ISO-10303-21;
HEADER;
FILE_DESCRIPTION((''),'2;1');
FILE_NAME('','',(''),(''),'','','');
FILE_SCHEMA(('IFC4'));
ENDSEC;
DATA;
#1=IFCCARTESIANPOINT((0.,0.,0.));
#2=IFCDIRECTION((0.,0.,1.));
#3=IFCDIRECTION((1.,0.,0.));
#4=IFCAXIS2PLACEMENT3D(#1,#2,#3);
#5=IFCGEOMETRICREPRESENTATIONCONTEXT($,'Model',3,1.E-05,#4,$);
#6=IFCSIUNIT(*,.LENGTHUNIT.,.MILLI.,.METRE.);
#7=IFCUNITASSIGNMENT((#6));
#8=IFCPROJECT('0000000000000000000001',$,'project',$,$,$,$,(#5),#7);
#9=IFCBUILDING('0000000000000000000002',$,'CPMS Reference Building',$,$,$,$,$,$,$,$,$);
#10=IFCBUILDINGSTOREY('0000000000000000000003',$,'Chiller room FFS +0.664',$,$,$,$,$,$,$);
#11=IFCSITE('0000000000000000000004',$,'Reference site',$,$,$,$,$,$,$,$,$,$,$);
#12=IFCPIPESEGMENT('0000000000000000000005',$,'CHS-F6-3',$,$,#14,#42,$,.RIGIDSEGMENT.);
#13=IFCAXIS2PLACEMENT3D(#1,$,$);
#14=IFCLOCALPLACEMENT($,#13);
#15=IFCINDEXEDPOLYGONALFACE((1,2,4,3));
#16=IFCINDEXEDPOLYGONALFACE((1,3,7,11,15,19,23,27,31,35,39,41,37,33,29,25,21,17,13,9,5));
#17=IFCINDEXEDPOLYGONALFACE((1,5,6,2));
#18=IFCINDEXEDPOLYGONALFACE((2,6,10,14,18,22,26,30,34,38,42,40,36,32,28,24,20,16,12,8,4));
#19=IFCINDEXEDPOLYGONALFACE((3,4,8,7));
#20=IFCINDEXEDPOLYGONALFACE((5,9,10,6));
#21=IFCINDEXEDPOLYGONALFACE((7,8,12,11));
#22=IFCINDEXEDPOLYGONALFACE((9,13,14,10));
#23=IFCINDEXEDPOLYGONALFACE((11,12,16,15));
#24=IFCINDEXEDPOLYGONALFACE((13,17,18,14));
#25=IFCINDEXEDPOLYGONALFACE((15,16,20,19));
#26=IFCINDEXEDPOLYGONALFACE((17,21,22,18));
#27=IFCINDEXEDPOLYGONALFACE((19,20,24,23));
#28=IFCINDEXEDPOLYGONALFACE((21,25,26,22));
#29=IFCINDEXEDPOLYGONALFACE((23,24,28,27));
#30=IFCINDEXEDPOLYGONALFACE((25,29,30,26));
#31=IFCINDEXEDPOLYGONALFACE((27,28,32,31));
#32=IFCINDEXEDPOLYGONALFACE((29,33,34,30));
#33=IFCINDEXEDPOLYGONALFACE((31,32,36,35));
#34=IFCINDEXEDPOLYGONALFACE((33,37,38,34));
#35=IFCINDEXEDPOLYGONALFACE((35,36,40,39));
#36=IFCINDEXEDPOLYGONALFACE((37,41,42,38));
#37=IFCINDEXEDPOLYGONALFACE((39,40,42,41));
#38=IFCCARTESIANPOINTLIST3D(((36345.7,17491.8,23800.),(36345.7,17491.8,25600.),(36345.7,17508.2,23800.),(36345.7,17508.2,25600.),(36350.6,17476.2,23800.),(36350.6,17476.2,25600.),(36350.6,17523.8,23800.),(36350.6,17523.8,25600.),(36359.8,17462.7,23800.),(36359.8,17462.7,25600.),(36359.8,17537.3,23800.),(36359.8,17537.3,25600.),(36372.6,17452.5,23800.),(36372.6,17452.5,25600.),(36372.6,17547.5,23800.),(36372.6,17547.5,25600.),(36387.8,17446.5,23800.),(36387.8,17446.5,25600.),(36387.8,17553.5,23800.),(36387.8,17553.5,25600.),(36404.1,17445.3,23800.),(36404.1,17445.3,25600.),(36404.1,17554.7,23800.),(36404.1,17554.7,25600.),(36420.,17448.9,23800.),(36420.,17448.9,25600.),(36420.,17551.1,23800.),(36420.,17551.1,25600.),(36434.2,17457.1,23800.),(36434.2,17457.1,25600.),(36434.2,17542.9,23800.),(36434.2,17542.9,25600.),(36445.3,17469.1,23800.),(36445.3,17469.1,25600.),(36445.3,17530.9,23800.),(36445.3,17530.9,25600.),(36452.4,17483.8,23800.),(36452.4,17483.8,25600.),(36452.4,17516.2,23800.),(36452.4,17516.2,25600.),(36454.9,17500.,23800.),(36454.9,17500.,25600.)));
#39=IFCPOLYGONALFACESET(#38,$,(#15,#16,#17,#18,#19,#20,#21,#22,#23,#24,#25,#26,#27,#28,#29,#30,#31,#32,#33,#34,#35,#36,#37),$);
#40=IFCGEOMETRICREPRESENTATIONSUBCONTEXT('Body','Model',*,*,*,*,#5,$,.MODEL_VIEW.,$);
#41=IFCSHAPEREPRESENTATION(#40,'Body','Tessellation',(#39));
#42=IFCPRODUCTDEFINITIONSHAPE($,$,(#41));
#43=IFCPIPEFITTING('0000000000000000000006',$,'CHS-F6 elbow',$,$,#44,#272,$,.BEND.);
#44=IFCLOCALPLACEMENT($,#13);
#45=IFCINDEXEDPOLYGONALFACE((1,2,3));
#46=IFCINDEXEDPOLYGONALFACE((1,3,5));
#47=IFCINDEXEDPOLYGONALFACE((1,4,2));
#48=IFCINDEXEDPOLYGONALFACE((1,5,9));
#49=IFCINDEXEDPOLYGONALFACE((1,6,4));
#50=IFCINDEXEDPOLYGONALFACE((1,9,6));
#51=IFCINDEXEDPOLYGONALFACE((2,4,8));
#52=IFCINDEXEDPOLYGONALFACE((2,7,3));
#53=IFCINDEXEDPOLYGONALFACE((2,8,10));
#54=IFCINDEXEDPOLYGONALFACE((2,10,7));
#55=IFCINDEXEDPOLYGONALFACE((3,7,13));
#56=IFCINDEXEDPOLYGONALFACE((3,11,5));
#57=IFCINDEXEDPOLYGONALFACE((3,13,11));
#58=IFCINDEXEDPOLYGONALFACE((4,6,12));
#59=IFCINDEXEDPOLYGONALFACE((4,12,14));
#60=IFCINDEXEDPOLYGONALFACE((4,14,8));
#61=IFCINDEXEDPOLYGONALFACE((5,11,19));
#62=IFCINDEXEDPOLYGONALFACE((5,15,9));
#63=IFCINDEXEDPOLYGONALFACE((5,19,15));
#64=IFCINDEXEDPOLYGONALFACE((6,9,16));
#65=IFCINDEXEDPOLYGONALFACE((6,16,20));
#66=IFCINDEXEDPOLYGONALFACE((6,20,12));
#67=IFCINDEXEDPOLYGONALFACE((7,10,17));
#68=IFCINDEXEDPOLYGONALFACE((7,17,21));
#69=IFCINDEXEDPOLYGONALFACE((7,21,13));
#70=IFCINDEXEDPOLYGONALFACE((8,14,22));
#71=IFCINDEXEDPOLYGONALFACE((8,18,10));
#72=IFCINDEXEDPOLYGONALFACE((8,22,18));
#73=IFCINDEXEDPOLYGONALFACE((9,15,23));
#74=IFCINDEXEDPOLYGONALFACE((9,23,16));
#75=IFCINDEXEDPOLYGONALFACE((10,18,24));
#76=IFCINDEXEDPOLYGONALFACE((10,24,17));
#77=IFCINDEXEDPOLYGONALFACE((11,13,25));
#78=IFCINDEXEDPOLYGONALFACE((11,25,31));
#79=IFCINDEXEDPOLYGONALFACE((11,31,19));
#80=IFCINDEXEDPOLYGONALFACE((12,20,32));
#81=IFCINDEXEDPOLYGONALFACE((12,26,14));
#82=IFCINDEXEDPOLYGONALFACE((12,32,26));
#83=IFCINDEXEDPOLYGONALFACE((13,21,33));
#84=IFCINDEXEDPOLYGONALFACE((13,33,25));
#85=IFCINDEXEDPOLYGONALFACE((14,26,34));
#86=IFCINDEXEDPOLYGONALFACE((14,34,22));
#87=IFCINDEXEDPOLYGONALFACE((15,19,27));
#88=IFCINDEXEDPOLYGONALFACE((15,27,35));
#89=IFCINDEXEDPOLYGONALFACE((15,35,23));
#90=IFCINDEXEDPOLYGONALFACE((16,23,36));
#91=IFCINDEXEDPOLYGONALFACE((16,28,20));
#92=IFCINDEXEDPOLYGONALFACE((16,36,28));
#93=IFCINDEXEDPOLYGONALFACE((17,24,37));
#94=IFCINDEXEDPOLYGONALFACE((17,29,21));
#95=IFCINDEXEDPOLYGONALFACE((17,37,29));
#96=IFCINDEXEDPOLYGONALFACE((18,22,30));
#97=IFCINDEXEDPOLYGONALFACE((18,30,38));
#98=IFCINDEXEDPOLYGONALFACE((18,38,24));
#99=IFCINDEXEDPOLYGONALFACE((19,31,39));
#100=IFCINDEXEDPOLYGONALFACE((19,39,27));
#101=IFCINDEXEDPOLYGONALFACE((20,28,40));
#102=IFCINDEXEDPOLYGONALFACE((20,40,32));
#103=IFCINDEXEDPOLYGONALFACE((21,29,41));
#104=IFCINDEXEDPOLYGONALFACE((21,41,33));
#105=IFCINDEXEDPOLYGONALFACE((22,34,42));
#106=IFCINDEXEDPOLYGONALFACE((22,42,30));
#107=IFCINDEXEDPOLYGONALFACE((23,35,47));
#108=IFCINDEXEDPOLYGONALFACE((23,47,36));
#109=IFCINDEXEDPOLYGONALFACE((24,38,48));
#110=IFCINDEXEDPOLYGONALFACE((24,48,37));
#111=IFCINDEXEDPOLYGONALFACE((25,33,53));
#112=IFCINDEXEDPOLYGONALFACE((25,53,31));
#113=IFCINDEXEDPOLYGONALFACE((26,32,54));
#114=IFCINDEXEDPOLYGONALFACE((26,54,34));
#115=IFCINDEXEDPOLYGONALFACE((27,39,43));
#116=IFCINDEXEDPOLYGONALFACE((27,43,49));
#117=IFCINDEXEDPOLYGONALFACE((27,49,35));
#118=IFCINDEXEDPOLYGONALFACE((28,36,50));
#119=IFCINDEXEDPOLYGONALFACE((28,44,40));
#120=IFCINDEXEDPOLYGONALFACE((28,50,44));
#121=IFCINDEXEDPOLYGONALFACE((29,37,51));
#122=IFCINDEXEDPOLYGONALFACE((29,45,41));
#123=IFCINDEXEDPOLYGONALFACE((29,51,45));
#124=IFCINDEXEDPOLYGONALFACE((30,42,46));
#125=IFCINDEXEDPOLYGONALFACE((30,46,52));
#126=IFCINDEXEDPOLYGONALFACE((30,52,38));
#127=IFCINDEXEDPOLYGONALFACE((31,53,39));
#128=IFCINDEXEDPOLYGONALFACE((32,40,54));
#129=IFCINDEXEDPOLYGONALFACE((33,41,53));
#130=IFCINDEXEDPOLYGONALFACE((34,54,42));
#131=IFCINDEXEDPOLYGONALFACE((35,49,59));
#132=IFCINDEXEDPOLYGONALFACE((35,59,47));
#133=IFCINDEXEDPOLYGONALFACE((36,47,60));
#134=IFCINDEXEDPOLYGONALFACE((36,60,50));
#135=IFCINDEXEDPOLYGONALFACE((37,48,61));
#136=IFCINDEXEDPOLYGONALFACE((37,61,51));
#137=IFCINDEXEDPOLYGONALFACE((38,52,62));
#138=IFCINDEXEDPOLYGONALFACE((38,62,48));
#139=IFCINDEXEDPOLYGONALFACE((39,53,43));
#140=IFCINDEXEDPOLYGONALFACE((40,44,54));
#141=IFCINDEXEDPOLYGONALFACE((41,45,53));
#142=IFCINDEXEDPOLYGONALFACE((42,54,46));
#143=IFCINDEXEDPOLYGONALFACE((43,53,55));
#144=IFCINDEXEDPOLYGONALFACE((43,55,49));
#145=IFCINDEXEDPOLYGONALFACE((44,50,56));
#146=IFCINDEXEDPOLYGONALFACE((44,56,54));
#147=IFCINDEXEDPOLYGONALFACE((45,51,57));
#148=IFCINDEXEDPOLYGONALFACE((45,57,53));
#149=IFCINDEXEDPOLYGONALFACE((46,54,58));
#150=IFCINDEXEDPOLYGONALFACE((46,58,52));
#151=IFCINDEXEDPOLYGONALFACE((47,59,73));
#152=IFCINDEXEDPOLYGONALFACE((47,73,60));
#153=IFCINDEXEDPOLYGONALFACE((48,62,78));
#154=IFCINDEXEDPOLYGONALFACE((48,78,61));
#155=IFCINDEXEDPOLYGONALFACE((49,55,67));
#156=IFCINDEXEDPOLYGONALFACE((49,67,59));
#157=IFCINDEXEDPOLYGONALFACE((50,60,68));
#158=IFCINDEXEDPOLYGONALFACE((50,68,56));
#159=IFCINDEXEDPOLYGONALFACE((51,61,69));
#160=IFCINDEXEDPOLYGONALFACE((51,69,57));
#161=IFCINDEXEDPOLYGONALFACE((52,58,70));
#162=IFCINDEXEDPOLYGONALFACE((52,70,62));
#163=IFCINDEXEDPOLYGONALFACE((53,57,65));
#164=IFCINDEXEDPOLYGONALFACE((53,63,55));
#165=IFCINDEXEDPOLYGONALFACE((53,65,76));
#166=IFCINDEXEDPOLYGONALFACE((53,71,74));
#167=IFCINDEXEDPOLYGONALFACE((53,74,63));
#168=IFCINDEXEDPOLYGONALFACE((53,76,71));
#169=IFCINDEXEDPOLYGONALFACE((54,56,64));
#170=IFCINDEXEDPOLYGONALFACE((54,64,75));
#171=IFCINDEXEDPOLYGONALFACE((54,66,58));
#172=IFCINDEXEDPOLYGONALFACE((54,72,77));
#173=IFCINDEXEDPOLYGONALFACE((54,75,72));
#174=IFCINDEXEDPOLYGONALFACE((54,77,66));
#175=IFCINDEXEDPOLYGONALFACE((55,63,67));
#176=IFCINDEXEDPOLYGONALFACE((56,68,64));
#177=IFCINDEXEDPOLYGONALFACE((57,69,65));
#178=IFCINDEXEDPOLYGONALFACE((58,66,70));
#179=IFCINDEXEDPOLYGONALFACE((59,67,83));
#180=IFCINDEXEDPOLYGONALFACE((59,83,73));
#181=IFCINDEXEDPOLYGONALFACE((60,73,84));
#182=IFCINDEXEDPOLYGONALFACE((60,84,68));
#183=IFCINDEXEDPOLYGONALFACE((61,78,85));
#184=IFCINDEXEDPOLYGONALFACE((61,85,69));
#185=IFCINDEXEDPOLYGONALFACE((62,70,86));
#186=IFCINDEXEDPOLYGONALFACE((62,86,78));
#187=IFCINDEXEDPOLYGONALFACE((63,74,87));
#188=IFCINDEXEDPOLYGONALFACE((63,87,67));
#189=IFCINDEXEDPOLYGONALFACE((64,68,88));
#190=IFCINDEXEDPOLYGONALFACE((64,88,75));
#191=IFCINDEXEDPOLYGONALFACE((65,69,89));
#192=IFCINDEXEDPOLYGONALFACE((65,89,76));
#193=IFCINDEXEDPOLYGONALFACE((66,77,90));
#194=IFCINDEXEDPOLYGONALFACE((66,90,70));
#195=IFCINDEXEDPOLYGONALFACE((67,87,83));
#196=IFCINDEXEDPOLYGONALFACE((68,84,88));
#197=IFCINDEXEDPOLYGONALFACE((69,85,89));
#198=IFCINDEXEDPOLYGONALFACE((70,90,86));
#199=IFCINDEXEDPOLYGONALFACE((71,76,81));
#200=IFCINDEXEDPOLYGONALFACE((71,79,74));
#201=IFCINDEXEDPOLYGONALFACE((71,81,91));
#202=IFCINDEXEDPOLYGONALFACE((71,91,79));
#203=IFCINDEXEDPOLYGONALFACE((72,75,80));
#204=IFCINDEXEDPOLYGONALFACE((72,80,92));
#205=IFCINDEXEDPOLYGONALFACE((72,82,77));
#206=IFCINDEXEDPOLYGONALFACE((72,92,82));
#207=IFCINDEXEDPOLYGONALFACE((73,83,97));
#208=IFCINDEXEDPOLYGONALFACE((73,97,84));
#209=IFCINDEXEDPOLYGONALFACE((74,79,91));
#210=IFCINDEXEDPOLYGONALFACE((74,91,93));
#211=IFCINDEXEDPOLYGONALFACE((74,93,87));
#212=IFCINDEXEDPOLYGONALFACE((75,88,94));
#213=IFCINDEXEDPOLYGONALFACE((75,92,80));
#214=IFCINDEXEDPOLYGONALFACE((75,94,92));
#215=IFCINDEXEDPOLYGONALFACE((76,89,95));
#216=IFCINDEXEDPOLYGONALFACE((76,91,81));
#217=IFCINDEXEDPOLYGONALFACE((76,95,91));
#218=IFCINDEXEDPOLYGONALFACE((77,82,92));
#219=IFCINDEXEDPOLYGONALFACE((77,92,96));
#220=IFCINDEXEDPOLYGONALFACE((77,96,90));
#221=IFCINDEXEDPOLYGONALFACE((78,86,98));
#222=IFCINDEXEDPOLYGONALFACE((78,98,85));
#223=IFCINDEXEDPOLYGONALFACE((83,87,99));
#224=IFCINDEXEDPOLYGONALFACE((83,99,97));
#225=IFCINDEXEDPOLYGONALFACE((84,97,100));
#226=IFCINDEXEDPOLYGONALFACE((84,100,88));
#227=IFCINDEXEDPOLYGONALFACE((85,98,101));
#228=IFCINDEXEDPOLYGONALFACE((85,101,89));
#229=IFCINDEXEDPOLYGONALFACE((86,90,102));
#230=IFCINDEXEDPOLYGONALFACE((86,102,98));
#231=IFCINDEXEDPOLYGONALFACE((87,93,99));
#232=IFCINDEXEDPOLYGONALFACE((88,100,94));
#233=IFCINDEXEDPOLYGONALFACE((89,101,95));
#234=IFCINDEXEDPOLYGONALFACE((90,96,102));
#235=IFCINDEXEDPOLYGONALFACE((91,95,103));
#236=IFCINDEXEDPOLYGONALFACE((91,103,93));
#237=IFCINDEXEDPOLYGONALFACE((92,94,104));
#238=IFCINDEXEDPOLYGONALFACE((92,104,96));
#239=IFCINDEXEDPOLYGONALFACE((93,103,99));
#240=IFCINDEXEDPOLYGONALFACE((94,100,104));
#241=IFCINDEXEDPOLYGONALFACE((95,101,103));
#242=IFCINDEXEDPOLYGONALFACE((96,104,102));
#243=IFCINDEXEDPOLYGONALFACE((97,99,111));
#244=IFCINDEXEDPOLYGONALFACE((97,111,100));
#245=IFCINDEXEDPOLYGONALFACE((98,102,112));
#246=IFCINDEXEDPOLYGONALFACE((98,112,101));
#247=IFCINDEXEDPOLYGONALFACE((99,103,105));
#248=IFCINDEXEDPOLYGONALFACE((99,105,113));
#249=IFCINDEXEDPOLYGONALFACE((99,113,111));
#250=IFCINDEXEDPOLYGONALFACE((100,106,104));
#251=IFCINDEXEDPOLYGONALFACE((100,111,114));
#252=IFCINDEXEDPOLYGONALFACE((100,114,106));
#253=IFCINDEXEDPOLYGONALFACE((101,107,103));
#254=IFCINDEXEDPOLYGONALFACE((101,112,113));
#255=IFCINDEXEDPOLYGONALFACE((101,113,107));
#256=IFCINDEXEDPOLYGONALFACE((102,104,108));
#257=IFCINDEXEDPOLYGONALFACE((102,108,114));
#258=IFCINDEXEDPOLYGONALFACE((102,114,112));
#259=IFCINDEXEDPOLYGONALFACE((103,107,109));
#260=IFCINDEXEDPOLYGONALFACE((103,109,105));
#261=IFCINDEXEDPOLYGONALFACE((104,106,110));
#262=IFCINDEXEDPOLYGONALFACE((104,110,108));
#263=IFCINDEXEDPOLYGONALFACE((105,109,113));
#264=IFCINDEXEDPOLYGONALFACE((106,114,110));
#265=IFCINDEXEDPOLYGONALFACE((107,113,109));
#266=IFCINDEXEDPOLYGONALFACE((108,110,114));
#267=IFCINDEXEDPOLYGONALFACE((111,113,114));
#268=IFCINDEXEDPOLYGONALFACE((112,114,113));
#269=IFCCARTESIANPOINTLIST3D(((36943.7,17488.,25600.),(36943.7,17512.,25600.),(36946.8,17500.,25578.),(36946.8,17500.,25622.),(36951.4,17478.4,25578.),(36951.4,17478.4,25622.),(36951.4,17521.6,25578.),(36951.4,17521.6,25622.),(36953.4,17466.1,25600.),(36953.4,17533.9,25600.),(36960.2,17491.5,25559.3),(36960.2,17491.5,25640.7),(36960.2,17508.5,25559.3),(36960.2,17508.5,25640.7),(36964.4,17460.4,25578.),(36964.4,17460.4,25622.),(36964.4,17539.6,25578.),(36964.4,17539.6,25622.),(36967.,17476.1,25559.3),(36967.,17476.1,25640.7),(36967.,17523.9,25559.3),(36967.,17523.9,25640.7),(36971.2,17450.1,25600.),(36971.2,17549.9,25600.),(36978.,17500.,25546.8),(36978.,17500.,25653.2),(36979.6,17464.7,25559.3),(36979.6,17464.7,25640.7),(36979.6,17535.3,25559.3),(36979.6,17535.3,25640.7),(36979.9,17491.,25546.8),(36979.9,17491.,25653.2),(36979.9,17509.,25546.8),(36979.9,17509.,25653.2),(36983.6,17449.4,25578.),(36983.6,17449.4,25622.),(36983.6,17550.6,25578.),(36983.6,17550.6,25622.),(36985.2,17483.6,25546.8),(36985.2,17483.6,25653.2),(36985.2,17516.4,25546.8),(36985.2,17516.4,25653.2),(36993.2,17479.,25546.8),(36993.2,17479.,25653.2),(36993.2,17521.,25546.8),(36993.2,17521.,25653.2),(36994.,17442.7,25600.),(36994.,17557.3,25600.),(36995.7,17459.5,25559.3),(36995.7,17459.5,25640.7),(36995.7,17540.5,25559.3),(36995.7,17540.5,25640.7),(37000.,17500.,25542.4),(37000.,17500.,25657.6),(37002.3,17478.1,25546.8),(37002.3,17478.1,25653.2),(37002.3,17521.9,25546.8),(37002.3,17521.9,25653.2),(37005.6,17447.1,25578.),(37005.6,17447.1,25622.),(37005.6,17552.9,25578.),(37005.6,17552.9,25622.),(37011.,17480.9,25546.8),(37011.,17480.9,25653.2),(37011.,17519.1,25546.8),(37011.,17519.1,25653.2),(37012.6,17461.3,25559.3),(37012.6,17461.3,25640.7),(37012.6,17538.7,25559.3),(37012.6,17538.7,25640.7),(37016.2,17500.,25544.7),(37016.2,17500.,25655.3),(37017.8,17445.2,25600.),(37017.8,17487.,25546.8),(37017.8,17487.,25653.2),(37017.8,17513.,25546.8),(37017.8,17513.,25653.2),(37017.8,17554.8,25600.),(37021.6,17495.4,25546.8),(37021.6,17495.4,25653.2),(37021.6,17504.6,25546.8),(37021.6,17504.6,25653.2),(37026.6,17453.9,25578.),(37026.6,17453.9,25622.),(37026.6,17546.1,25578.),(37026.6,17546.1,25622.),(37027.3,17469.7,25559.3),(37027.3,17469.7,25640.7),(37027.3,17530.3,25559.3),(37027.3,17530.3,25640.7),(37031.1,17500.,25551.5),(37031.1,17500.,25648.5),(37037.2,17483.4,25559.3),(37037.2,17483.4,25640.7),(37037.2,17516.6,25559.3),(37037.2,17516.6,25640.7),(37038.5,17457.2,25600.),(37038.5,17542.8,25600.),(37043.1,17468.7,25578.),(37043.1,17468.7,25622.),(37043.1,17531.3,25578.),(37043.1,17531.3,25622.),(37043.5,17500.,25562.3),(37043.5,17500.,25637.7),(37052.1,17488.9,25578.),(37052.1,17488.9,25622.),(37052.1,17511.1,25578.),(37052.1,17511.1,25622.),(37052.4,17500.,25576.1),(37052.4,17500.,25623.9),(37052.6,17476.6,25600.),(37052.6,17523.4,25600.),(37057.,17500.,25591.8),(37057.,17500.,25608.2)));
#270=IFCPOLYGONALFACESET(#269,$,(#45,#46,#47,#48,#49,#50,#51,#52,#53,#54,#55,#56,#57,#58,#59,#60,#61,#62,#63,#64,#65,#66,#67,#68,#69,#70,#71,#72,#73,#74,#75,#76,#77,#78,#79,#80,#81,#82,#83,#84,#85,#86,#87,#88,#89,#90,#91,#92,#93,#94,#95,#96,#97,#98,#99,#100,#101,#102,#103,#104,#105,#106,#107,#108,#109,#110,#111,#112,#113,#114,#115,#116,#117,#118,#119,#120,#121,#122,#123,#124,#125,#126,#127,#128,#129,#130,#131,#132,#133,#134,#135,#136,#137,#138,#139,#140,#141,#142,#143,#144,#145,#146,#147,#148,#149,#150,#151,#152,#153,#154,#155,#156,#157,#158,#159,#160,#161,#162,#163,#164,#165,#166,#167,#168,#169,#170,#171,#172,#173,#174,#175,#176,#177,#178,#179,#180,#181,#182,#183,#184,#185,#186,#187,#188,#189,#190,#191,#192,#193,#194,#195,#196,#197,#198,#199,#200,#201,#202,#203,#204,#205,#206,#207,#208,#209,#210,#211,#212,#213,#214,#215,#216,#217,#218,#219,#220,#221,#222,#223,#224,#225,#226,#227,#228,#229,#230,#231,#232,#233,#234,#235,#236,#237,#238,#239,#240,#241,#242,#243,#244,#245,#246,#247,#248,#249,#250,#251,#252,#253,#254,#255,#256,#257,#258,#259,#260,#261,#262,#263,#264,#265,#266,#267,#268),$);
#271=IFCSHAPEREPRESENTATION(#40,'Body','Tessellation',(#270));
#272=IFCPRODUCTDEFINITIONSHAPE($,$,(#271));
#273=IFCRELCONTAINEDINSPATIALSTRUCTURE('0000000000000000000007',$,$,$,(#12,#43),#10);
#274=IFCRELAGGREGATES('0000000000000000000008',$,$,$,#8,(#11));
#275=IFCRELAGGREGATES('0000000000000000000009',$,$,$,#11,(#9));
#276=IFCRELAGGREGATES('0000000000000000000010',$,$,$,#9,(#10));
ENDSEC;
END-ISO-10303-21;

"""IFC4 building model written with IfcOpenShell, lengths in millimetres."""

from ifc_helpers import new_model, entity, si_unit, frame, origin_with_axes, origin_2d, place, context, subcontext, project, spatial, circle_curve, outline, extrude, element, save


model = new_model("IFC4")

# Units and contexts
model_context = context("Model", 3, precision=1e-05, world=origin_with_axes())
body_context = subcontext(model_context, "Body", "Model", "MODEL_VIEW")
ifc_project = project(units=[si_unit("LENGTHUNIT", "METRE", prefix="MILLI")], contexts=[model_context])

# Site, building, storey
site = spatial("IfcSite", under=ifc_project, Name="Reference site")
building = spatial("IfcBuilding", under=site, Name="CPMS Reference Building")
storey = spatial("IfcBuildingStorey", under=building, Name="Chiller room FFS +0.664")

# Pipe segment
pipe_segment_1_placement = place(None, origin_with_axes())
element("IfcPipeSegment", 1, at=pipe_segment_1_placement, inside=storey, Name="CHS-F6-3", PredefinedType="RIGIDSEGMENT", context=body_context, shape_type="SweptSolid", body=[
    extrude(outline(circle_curve(origin_2d(), 54.9)), frame((36400.0, 17500.0, 25600.0), z_axis=(0.0, 0.0, -1.0), x_axis=(1.0, 0.0, 0.0)), (0.0, 0.0, 1.0), 1800.0),
])

# Pipe fitting
pipe_fitting_1_placement = place(None, origin_with_axes())
element("IfcPipeFitting", 2, at=pipe_fitting_1_placement, inside=storey, Name="CHS-F6 elbow", PredefinedType="BEND", context=body_context, shape_type="CSG", body=[
    entity("IfcSphere", entity("IfcAxis2Placement3D", entity("IfcCartesianPoint", [37000.0, 17500.0, 25600.0]), entity("IfcDirection", [0.0, 0.0, 1.0]), entity("IfcDirection", [1.0, 0.0, 0.0])), 57.6),
])

save(model, "model.ifc")
